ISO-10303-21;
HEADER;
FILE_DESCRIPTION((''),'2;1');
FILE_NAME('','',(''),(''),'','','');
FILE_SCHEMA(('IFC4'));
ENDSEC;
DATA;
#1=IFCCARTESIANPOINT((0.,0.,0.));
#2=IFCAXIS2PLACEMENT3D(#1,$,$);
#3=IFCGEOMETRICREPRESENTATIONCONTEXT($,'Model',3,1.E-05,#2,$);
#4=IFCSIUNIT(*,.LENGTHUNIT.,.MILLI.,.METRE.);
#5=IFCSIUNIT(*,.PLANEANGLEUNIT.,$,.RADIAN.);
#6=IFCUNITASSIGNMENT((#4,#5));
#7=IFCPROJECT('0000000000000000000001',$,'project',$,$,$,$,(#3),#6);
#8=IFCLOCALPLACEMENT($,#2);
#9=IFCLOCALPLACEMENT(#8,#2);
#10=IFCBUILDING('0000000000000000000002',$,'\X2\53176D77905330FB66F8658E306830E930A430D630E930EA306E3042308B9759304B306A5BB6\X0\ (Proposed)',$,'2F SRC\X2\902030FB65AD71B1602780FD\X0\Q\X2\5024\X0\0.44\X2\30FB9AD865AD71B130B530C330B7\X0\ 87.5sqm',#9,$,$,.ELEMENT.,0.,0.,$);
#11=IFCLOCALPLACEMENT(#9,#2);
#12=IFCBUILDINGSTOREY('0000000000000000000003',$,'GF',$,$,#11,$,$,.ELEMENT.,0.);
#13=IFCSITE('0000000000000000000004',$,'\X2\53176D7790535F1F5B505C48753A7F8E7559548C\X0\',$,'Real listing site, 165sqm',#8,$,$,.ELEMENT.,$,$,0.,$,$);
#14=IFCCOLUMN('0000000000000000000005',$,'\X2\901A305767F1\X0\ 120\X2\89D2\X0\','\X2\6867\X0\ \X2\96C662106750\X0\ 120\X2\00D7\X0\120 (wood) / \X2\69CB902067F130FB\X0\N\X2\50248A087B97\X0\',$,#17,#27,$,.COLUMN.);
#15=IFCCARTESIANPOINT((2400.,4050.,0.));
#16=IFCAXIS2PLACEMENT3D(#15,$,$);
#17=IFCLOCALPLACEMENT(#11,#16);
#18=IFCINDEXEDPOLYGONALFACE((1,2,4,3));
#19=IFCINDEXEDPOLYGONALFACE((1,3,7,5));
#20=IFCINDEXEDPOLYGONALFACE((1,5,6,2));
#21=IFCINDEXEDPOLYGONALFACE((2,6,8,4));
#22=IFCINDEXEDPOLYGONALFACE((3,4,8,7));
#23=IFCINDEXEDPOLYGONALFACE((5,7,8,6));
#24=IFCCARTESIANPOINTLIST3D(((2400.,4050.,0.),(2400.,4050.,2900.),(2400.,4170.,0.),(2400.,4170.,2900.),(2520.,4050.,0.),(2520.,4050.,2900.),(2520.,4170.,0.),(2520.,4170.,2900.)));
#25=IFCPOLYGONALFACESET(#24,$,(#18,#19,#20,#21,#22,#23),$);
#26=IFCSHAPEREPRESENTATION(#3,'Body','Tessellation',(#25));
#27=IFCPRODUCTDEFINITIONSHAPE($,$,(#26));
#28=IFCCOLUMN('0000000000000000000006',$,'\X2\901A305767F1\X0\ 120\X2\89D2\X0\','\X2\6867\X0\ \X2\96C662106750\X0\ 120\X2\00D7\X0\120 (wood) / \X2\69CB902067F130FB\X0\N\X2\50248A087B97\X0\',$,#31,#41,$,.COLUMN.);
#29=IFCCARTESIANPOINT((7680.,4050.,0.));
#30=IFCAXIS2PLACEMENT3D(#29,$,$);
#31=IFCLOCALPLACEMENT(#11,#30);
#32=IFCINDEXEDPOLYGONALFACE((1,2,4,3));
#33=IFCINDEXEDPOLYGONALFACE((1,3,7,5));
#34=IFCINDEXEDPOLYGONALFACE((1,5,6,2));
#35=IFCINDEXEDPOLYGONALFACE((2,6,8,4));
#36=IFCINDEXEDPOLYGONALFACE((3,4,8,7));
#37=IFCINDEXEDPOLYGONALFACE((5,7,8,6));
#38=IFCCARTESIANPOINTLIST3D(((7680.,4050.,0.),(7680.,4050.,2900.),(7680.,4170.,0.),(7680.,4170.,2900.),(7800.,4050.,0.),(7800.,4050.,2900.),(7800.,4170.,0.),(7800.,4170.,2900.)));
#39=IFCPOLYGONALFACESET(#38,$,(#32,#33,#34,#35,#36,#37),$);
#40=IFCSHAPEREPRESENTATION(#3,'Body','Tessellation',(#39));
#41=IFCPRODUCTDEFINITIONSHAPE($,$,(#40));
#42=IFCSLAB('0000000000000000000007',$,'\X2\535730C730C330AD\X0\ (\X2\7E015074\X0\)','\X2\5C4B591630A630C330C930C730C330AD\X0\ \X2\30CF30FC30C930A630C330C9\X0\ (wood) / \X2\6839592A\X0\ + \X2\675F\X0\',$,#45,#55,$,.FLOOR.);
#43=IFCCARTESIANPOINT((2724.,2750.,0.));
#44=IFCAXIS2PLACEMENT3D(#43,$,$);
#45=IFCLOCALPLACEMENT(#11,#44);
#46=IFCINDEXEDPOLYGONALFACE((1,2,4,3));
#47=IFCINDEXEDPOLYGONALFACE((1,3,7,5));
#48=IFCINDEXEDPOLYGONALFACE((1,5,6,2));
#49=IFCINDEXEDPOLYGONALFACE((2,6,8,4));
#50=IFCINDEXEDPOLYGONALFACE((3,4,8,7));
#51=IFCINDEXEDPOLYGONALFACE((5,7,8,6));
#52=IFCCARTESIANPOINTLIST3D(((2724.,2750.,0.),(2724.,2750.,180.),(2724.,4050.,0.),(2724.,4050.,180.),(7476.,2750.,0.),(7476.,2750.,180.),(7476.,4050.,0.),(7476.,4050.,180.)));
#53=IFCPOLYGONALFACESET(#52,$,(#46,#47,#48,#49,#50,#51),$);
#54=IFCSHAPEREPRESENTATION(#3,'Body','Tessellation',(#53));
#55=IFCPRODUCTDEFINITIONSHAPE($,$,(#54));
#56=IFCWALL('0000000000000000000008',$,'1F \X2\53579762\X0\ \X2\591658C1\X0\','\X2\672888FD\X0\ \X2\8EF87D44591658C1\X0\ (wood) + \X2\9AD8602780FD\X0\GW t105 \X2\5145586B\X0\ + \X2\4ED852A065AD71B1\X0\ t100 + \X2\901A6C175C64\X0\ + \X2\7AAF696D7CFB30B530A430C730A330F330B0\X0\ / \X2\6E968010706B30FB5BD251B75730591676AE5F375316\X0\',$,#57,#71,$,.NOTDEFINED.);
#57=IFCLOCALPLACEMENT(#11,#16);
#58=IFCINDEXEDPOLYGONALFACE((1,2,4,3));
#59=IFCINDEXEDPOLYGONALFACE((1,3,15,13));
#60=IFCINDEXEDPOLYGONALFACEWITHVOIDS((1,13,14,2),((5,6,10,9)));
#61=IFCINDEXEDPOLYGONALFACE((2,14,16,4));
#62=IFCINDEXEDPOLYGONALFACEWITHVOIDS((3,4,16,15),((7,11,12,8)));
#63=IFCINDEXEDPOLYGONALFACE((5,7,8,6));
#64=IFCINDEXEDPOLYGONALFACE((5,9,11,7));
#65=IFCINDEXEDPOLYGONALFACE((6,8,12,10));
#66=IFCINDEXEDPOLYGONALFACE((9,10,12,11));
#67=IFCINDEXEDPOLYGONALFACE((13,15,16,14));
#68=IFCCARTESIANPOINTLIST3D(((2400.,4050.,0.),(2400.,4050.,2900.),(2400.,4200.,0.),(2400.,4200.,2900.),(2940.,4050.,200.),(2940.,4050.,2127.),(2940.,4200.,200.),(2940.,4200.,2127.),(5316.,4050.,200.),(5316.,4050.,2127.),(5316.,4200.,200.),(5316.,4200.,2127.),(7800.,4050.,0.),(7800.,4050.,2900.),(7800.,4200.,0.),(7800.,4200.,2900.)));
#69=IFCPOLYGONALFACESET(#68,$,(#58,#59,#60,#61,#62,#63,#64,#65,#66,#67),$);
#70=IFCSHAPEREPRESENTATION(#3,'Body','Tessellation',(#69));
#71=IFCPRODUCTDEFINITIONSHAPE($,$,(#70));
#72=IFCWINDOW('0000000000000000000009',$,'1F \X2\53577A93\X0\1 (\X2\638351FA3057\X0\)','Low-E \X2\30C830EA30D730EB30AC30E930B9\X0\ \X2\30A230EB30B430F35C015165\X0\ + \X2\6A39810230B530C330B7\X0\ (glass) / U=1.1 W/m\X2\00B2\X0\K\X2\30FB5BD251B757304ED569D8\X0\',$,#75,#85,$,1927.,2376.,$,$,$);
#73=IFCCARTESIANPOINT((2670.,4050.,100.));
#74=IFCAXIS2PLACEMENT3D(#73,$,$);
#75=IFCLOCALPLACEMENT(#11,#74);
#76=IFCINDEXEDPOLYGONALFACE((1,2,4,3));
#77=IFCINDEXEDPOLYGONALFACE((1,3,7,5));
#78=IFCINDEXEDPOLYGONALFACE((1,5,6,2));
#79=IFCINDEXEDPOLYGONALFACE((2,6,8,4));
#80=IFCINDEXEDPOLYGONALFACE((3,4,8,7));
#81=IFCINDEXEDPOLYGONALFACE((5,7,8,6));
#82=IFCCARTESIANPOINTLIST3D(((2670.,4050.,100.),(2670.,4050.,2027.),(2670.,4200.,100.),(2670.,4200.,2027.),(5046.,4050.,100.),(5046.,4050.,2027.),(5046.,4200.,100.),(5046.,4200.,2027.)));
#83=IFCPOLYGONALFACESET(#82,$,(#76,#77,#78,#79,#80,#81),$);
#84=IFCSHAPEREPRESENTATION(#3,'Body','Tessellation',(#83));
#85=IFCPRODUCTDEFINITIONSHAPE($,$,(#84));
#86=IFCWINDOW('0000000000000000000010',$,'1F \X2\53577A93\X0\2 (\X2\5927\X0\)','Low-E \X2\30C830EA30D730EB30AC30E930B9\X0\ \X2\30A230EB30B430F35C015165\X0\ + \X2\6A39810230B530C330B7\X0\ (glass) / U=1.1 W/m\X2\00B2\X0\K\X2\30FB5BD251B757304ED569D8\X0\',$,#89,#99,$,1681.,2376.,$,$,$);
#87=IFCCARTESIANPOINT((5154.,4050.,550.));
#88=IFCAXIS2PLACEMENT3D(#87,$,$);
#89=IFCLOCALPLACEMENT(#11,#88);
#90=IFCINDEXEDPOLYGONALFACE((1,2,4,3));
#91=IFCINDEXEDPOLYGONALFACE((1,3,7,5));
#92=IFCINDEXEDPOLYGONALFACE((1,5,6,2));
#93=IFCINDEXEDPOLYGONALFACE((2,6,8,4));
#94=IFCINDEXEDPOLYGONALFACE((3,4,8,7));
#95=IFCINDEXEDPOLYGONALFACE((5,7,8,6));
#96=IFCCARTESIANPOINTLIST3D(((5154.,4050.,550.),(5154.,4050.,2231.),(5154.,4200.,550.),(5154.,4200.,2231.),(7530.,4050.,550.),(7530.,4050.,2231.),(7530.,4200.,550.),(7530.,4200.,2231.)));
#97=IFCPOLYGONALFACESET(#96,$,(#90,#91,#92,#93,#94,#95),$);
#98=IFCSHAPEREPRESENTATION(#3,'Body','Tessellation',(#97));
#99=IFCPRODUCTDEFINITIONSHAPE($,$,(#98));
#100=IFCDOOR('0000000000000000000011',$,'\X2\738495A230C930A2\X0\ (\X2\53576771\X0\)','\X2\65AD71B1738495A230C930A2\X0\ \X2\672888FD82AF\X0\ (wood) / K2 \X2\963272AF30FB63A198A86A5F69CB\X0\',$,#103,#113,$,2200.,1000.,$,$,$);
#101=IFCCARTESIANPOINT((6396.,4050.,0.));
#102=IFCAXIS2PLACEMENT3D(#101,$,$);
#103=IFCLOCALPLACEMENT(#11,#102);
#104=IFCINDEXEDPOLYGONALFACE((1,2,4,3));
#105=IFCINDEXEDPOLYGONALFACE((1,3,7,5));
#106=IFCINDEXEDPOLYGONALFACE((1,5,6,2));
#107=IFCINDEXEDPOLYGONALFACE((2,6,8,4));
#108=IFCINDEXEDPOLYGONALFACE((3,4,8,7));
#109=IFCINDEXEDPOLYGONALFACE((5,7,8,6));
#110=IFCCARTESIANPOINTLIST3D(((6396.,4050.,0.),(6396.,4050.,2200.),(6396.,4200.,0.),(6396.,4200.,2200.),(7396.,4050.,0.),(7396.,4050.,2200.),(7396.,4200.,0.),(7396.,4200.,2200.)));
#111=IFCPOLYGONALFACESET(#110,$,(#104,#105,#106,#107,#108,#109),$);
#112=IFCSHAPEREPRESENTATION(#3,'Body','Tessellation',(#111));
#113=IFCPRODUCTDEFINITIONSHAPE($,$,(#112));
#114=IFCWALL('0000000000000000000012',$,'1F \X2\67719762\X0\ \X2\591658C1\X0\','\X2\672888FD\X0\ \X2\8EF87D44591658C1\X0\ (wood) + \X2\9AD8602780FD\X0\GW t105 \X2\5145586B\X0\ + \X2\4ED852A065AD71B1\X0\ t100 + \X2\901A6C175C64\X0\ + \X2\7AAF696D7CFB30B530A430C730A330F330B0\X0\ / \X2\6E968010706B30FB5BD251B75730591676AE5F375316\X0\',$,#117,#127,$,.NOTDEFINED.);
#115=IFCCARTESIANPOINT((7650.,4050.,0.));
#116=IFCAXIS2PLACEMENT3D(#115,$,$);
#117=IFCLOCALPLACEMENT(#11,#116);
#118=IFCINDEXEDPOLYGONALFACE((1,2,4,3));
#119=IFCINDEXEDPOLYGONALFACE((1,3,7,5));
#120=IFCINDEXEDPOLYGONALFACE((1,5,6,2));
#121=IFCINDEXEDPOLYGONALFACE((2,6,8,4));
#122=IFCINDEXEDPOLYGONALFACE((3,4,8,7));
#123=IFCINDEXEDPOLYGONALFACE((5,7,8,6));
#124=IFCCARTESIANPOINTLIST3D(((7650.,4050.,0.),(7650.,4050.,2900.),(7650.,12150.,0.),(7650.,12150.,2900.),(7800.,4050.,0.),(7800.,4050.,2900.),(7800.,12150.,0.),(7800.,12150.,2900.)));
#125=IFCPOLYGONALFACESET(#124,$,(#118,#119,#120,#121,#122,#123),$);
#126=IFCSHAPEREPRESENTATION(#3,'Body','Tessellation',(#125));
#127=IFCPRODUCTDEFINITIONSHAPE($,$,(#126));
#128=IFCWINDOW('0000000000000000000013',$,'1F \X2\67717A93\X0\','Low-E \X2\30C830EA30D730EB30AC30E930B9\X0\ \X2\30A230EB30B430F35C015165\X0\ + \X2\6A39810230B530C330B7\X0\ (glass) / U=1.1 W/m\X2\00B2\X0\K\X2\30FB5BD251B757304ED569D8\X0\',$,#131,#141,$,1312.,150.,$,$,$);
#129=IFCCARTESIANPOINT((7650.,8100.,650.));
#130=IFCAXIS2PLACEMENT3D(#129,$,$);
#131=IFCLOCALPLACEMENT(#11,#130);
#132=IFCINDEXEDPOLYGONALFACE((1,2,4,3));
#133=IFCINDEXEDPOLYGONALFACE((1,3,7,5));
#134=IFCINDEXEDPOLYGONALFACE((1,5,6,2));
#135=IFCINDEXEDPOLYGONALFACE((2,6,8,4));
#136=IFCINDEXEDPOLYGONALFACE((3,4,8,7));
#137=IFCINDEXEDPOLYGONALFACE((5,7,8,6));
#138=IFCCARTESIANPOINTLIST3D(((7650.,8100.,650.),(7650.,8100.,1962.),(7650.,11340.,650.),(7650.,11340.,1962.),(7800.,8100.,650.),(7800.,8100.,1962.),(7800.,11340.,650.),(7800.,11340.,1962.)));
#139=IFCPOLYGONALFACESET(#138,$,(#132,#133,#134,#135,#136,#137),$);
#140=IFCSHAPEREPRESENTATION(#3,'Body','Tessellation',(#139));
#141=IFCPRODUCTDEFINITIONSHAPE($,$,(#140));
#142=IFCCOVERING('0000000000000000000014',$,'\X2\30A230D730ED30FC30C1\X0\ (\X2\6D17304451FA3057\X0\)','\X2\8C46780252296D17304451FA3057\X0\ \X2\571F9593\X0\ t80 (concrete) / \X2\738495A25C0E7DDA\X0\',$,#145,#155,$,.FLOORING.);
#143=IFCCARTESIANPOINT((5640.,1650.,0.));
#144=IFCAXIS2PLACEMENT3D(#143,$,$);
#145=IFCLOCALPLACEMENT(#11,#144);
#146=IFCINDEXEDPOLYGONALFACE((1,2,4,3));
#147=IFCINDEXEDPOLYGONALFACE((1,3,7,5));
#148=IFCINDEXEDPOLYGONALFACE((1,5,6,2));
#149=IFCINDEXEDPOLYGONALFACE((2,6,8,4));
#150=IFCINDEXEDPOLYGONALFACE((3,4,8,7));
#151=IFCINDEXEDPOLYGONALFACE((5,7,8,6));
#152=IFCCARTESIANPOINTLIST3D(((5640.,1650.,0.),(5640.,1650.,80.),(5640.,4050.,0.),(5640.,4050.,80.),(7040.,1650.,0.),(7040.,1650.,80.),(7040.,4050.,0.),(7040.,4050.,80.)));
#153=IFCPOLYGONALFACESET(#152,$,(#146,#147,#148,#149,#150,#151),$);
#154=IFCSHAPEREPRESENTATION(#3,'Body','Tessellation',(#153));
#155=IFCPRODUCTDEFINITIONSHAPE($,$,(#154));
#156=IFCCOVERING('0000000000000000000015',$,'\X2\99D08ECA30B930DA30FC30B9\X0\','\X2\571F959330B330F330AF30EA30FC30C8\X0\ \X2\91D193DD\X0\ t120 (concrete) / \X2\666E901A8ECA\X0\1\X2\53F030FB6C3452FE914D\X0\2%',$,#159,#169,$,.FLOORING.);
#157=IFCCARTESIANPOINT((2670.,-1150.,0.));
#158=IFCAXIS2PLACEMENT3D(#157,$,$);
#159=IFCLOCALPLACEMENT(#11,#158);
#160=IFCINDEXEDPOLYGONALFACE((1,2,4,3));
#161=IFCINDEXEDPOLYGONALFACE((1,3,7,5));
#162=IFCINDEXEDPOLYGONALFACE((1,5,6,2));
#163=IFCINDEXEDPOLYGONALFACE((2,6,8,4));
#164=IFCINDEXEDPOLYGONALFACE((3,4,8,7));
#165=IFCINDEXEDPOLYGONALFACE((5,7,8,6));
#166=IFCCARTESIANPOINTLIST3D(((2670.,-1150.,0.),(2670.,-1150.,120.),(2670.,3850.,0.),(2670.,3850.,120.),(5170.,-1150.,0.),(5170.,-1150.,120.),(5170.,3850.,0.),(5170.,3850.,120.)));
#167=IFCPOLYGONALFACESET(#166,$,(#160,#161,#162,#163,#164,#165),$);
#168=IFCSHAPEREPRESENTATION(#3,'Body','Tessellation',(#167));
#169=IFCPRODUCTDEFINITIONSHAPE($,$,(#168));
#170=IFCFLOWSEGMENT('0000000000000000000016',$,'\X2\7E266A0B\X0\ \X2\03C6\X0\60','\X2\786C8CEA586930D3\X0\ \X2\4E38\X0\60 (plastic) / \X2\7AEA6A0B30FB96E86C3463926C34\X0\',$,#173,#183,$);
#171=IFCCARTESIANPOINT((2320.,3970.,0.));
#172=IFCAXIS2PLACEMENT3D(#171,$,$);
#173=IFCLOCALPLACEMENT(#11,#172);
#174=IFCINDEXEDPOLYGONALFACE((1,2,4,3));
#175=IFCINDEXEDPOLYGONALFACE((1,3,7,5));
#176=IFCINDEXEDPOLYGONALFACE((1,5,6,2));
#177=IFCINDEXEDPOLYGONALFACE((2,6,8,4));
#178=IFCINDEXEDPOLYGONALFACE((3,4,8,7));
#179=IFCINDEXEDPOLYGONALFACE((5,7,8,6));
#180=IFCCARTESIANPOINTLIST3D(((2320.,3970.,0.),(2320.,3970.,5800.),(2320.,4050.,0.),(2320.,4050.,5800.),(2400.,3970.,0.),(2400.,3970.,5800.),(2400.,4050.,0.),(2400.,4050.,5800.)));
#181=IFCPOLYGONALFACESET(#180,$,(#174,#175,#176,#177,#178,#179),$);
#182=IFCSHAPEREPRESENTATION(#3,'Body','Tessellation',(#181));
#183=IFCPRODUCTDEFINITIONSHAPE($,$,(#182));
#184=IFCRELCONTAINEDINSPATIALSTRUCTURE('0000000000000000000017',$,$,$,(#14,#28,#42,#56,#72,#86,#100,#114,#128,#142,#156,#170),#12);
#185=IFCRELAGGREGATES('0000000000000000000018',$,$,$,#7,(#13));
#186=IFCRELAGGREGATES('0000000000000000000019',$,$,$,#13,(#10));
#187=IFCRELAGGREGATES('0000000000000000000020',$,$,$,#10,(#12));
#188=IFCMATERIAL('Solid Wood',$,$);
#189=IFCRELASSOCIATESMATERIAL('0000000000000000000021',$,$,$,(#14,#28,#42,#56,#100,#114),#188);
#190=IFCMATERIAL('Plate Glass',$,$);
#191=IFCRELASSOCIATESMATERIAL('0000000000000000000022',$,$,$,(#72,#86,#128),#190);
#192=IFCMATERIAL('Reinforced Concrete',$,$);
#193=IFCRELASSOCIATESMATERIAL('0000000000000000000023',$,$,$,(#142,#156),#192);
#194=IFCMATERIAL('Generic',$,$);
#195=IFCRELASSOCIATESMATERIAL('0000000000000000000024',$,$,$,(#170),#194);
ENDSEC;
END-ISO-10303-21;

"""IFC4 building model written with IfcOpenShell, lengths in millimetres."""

from ifc_helpers import new_model, si_unit, frame, frame_2d, origin, place, context, project, spatial, rectangle, extrude, material, element, fill, save


model = new_model("IFC4")

# Units and contexts
model_context = context("Model", 3, precision=1e-05, world=origin())
ifc_project = project(units=[si_unit("LENGTHUNIT", "METRE", prefix="MILLI"), si_unit("PLANEANGLEUNIT", "RADIAN")], contexts=[model_context])

# Site, building, storey
site_placement = place(None, origin())
site = spatial("IfcSite", under=ifc_project, at=site_placement, Name="北海道弟子屈町美留和", ObjectType="Real listing site, 165sqm", CompositionType="ELEMENT", RefElevation=0.0)
building_placement = place(site_placement, origin())
building = spatial("IfcBuilding", under=site, at=building_placement, Name="北海道・書斎とライブラリのある静かな家 (Proposed)", ObjectType="2F SRC造・断熱性能Q値0.44・高断熱サッシ 87.5sqm", CompositionType="ELEMENT", ElevationOfRefHeight=0.0, ElevationOfTerrain=0.0)
storey_placement = place(building_placement, origin())
storey = spatial("IfcBuildingStorey", under=building, at=storey_placement, Name="GF", CompositionType="ELEMENT", Elevation=0.0)

# Columns
ifc_material_1 = material(Name="Solid Wood")
column_1_placement = place(storey_placement, frame((2400.0, 4050.0, 0.0)))
element("IfcColumn", 1, at=column_1_placement, inside=storey, material=ifc_material_1, Name="通し柱 120角", Description="桧 集成材 120×120 (wood) / 構造柱・N値計算", PredefinedType="COLUMN", context=model_context, shape_type="SweptSolid", body=[
    extrude(rectangle(XDim=120.0, YDim=120.0, at=frame_2d((60.0, 60.0))), frame((2400.0, 4050.0, 0.0)), (0.0, 0.0, 1.0), 2900.0),
])
column_2_placement = place(storey_placement, frame((7680.0, 4050.0, 0.0)))
element("IfcColumn", 2, at=column_2_placement, inside=storey, material=ifc_material_1, Name="通し柱 120角", Description="桧 集成材 120×120 (wood) / 構造柱・N値計算", PredefinedType="COLUMN", context=model_context, shape_type="SweptSolid", body=[
    extrude(rectangle(XDim=120.0, YDim=120.0, at=frame_2d((60.0, 60.0))), frame((7680.0, 4050.0, 0.0)), (0.0, 0.0, 1.0), 2900.0),
])

# Slab
ifc_material_2 = material(Name="Reinforced Concrete")
slab_1_placement = place(storey_placement, frame((2724.0, 2750.0, 0.0)))
element("IfcSlab", 3, at=slab_1_placement, inside=storey, material=ifc_material_1, Name="南デッキ (縁側)", Description="屋外ウッドデッキ ハードウッド (wood) / 根太 + 束", PredefinedType="FLOOR", context=model_context, shape_type="SweptSolid", body=[
    extrude(rectangle(XDim=4752.0, YDim=1300.0, at=frame_2d((2376.0, 650.0))), frame((2724.0, 2750.0, 0.0)), (0.0, 0.0, 1.0), 180.0),
])

# Wall, openings, windows, door
wall_1_placement = place(storey_placement, frame((2400.0, 4050.0, 0.0)))
wall_1 = element("IfcWall", 4, at=wall_1_placement, inside=storey, material=ifc_material_1, Name="1F 南面 外壁", Description="木製 軸組外壁 (wood) + 高性能GW t105 充填 + 付加断熱 t100 + 通気層 + 窯業系サイディング / 準耐火・寒冷地外皮強化", PredefinedType="NOTDEFINED", context=model_context, shape_type="SweptSolid", body=[
    extrude(rectangle(XDim=5400.0, YDim=150.0, at=frame_2d((2700.0, 75.0))), frame((2400.0, 4050.0, 0.0)), (0.0, 0.0, 1.0), 2900.0),
])
opening_1_placement = place(storey_placement, frame((2670.0, 4050.0, 100.0)))
opening_1 = element("IfcOpeningElement", 5, at=opening_1_placement, cuts=wall_1, PredefinedType="NOTDEFINED", context=model_context, shape_type="SweptSolid", body=[
    extrude(rectangle(XDim=2376.0, YDim=150.0, at=frame_2d((1188.0, 75.0))), frame((2670.0, 4050.0, 100.0)), (0.0, 0.0, 1.0), 1927.0),
])
opening_2_placement = place(storey_placement, frame((5154.0, 4050.0, 550.0)))
opening_2 = element("IfcOpeningElement", 6, at=opening_2_placement, cuts=wall_1, PredefinedType="NOTDEFINED", context=model_context, shape_type="SweptSolid", body=[
    extrude(rectangle(XDim=2376.0, YDim=150.0, at=frame_2d((1188.0, 75.0))), frame((5154.0, 4050.0, 550.0)), (0.0, 0.0, 1.0), 1681.0),
])
opening_3_placement = place(storey_placement, frame((6396.0, 4050.0, 0.0)))
opening_3 = element("IfcOpeningElement", 7, at=opening_3_placement, cuts=wall_1, PredefinedType="NOTDEFINED", context=model_context, shape_type="SweptSolid", body=[
    extrude(rectangle(XDim=1000.0, YDim=150.0, at=frame_2d((500.0, 75.0))), frame((6396.0, 4050.0, 0.0)), (0.0, 0.0, 1.0), 2200.0),
])
ifc_material_3 = material(Name="Plate Glass")
window_1_placement = place(storey_placement, frame((2670.0, 4050.0, 100.0)))
window_1 = element("IfcWindow", 8, at=window_1_placement, inside=storey, material=ifc_material_3, Name="1F 南窓1 (掃出し)", Description="Low-E トリプルガラス アルゴン封入 + 樹脂サッシ (glass) / U=1.1 W/m²K・寒冷地仕様", OverallHeight=1927.0, OverallWidth=2376.0, context=model_context, shape_type="SweptSolid", body=[
    extrude(rectangle(XDim=2376.0, YDim=150.0, at=frame_2d((1188.0, 75.0))), frame((2670.0, 4050.0, 100.0)), (0.0, 0.0, 1.0), 1927.0),
])
fill(opening_1, window_1)
window_2_placement = place(storey_placement, frame((5154.0, 4050.0, 550.0)))
window_2 = element("IfcWindow", 9, at=window_2_placement, inside=storey, material=ifc_material_3, Name="1F 南窓2 (大)", Description="Low-E トリプルガラス アルゴン封入 + 樹脂サッシ (glass) / U=1.1 W/m²K・寒冷地仕様", OverallHeight=1681.0, OverallWidth=2376.0, context=model_context, shape_type="SweptSolid", body=[
    extrude(rectangle(XDim=2376.0, YDim=150.0, at=frame_2d((1188.0, 75.0))), frame((5154.0, 4050.0, 550.0)), (0.0, 0.0, 1.0), 1681.0),
])
fill(opening_2, window_2)
door_placement = place(storey_placement, frame((6396.0, 4050.0, 0.0)))
door = element("IfcDoor", 10, at=door_placement, inside=storey, material=ifc_material_1, Name="玄関ドア (南東)", Description="断熱玄関ドア 木製芯 (wood) / K2 防犯・採風機構", OverallHeight=2200.0, OverallWidth=1000.0, context=model_context, shape_type="SweptSolid", body=[
    extrude(rectangle(XDim=1000.0, YDim=150.0, at=frame_2d((500.0, 75.0))), frame((6396.0, 4050.0, 0.0)), (0.0, 0.0, 1.0), 2200.0),
])
fill(opening_3, door)

# Wall, opening, window
wall_2_placement = place(storey_placement, frame((7650.0, 4050.0, 0.0)))
wall_2 = element("IfcWall", 11, at=wall_2_placement, inside=storey, material=ifc_material_1, Name="1F 東面 外壁", Description="木製 軸組外壁 (wood) + 高性能GW t105 充填 + 付加断熱 t100 + 通気層 + 窯業系サイディング / 準耐火・寒冷地外皮強化", PredefinedType="NOTDEFINED", context=model_context, shape_type="SweptSolid", body=[
    extrude(rectangle(XDim=150.0, YDim=8100.0, at=frame_2d((75.0, 4050.0))), frame((7650.0, 4050.0, 0.0)), (0.0, 0.0, 1.0), 2900.0),
])
opening_4_placement = place(storey_placement, frame((7650.0, 8100.0, 650.0)))
opening_4 = element("IfcOpeningElement", 12, at=opening_4_placement, cuts=wall_2, PredefinedType="NOTDEFINED", context=model_context, shape_type="SweptSolid", body=[
    extrude(rectangle(XDim=150.0, YDim=3240.0, at=frame_2d((75.0, 1620.0))), frame((7650.0, 8100.0, 650.0)), (0.0, 0.0, 1.0), 1312.0),
])
window_3_placement = place(storey_placement, frame((7650.0, 8100.0, 650.0)))
window_3 = element("IfcWindow", 13, at=window_3_placement, inside=storey, material=ifc_material_3, Name="1F 東窓", Description="Low-E トリプルガラス アルゴン封入 + 樹脂サッシ (glass) / U=1.1 W/m²K・寒冷地仕様", OverallHeight=1312.0, OverallWidth=150.0, context=model_context, shape_type="SweptSolid", body=[
    extrude(rectangle(XDim=150.0, YDim=3240.0, at=frame_2d((75.0, 1620.0))), frame((7650.0, 8100.0, 650.0)), (0.0, 0.0, 1.0), 1312.0),
])
fill(opening_4, window_3)

# Coverings
covering_1_placement = place(storey_placement, frame((5640.0, 1650.0, 0.0)))
element("IfcCovering", 14, at=covering_1_placement, inside=storey, material=ifc_material_2, Name="アプローチ (洗い出し)", Description="豆砂利洗い出し 土間 t80 (concrete) / 玄関導線", PredefinedType="FLOORING", context=model_context, shape_type="SweptSolid", body=[
    extrude(rectangle(XDim=1400.0, YDim=2400.0, at=frame_2d((700.0, 1200.0))), frame((5640.0, 1650.0, 0.0)), (0.0, 0.0, 1.0), 80.0),
])
covering_2_placement = place(storey_placement, frame((2670.0, -1150.0, 0.0)))
element("IfcCovering", 15, at=covering_2_placement, inside=storey, material=ifc_material_2, Name="駐車スペース", Description="土間コンクリート 金鏝 t120 (concrete) / 普通車1台・水勾配2%", PredefinedType="FLOORING", context=model_context, shape_type="SweptSolid", body=[
    extrude(rectangle(XDim=2500.0, YDim=5000.0, at=frame_2d((1250.0, 2500.0))), frame((2670.0, -1150.0, 0.0)), (0.0, 0.0, 1.0), 120.0),
])

# Flow segment
ifc_material_4 = material(Name="Generic")
flow_segment_1_placement = place(storey_placement, frame((2320.0, 3970.0, 0.0)))
element("IfcFlowSegment", 16, at=flow_segment_1_placement, inside=storey, material=ifc_material_4, Name="縦樋 φ60", Description="硬質塩ビ 丸60 (plastic) / 竪樋・雨水排水", context=model_context, shape_type="SweptSolid", body=[
    extrude(rectangle(XDim=80.0, YDim=80.0, at=frame_2d((40.0, 40.0))), frame((2320.0, 3970.0, 0.0)), (0.0, 0.0, 1.0), 5800.0),
])

save(model, "model.ifc")
